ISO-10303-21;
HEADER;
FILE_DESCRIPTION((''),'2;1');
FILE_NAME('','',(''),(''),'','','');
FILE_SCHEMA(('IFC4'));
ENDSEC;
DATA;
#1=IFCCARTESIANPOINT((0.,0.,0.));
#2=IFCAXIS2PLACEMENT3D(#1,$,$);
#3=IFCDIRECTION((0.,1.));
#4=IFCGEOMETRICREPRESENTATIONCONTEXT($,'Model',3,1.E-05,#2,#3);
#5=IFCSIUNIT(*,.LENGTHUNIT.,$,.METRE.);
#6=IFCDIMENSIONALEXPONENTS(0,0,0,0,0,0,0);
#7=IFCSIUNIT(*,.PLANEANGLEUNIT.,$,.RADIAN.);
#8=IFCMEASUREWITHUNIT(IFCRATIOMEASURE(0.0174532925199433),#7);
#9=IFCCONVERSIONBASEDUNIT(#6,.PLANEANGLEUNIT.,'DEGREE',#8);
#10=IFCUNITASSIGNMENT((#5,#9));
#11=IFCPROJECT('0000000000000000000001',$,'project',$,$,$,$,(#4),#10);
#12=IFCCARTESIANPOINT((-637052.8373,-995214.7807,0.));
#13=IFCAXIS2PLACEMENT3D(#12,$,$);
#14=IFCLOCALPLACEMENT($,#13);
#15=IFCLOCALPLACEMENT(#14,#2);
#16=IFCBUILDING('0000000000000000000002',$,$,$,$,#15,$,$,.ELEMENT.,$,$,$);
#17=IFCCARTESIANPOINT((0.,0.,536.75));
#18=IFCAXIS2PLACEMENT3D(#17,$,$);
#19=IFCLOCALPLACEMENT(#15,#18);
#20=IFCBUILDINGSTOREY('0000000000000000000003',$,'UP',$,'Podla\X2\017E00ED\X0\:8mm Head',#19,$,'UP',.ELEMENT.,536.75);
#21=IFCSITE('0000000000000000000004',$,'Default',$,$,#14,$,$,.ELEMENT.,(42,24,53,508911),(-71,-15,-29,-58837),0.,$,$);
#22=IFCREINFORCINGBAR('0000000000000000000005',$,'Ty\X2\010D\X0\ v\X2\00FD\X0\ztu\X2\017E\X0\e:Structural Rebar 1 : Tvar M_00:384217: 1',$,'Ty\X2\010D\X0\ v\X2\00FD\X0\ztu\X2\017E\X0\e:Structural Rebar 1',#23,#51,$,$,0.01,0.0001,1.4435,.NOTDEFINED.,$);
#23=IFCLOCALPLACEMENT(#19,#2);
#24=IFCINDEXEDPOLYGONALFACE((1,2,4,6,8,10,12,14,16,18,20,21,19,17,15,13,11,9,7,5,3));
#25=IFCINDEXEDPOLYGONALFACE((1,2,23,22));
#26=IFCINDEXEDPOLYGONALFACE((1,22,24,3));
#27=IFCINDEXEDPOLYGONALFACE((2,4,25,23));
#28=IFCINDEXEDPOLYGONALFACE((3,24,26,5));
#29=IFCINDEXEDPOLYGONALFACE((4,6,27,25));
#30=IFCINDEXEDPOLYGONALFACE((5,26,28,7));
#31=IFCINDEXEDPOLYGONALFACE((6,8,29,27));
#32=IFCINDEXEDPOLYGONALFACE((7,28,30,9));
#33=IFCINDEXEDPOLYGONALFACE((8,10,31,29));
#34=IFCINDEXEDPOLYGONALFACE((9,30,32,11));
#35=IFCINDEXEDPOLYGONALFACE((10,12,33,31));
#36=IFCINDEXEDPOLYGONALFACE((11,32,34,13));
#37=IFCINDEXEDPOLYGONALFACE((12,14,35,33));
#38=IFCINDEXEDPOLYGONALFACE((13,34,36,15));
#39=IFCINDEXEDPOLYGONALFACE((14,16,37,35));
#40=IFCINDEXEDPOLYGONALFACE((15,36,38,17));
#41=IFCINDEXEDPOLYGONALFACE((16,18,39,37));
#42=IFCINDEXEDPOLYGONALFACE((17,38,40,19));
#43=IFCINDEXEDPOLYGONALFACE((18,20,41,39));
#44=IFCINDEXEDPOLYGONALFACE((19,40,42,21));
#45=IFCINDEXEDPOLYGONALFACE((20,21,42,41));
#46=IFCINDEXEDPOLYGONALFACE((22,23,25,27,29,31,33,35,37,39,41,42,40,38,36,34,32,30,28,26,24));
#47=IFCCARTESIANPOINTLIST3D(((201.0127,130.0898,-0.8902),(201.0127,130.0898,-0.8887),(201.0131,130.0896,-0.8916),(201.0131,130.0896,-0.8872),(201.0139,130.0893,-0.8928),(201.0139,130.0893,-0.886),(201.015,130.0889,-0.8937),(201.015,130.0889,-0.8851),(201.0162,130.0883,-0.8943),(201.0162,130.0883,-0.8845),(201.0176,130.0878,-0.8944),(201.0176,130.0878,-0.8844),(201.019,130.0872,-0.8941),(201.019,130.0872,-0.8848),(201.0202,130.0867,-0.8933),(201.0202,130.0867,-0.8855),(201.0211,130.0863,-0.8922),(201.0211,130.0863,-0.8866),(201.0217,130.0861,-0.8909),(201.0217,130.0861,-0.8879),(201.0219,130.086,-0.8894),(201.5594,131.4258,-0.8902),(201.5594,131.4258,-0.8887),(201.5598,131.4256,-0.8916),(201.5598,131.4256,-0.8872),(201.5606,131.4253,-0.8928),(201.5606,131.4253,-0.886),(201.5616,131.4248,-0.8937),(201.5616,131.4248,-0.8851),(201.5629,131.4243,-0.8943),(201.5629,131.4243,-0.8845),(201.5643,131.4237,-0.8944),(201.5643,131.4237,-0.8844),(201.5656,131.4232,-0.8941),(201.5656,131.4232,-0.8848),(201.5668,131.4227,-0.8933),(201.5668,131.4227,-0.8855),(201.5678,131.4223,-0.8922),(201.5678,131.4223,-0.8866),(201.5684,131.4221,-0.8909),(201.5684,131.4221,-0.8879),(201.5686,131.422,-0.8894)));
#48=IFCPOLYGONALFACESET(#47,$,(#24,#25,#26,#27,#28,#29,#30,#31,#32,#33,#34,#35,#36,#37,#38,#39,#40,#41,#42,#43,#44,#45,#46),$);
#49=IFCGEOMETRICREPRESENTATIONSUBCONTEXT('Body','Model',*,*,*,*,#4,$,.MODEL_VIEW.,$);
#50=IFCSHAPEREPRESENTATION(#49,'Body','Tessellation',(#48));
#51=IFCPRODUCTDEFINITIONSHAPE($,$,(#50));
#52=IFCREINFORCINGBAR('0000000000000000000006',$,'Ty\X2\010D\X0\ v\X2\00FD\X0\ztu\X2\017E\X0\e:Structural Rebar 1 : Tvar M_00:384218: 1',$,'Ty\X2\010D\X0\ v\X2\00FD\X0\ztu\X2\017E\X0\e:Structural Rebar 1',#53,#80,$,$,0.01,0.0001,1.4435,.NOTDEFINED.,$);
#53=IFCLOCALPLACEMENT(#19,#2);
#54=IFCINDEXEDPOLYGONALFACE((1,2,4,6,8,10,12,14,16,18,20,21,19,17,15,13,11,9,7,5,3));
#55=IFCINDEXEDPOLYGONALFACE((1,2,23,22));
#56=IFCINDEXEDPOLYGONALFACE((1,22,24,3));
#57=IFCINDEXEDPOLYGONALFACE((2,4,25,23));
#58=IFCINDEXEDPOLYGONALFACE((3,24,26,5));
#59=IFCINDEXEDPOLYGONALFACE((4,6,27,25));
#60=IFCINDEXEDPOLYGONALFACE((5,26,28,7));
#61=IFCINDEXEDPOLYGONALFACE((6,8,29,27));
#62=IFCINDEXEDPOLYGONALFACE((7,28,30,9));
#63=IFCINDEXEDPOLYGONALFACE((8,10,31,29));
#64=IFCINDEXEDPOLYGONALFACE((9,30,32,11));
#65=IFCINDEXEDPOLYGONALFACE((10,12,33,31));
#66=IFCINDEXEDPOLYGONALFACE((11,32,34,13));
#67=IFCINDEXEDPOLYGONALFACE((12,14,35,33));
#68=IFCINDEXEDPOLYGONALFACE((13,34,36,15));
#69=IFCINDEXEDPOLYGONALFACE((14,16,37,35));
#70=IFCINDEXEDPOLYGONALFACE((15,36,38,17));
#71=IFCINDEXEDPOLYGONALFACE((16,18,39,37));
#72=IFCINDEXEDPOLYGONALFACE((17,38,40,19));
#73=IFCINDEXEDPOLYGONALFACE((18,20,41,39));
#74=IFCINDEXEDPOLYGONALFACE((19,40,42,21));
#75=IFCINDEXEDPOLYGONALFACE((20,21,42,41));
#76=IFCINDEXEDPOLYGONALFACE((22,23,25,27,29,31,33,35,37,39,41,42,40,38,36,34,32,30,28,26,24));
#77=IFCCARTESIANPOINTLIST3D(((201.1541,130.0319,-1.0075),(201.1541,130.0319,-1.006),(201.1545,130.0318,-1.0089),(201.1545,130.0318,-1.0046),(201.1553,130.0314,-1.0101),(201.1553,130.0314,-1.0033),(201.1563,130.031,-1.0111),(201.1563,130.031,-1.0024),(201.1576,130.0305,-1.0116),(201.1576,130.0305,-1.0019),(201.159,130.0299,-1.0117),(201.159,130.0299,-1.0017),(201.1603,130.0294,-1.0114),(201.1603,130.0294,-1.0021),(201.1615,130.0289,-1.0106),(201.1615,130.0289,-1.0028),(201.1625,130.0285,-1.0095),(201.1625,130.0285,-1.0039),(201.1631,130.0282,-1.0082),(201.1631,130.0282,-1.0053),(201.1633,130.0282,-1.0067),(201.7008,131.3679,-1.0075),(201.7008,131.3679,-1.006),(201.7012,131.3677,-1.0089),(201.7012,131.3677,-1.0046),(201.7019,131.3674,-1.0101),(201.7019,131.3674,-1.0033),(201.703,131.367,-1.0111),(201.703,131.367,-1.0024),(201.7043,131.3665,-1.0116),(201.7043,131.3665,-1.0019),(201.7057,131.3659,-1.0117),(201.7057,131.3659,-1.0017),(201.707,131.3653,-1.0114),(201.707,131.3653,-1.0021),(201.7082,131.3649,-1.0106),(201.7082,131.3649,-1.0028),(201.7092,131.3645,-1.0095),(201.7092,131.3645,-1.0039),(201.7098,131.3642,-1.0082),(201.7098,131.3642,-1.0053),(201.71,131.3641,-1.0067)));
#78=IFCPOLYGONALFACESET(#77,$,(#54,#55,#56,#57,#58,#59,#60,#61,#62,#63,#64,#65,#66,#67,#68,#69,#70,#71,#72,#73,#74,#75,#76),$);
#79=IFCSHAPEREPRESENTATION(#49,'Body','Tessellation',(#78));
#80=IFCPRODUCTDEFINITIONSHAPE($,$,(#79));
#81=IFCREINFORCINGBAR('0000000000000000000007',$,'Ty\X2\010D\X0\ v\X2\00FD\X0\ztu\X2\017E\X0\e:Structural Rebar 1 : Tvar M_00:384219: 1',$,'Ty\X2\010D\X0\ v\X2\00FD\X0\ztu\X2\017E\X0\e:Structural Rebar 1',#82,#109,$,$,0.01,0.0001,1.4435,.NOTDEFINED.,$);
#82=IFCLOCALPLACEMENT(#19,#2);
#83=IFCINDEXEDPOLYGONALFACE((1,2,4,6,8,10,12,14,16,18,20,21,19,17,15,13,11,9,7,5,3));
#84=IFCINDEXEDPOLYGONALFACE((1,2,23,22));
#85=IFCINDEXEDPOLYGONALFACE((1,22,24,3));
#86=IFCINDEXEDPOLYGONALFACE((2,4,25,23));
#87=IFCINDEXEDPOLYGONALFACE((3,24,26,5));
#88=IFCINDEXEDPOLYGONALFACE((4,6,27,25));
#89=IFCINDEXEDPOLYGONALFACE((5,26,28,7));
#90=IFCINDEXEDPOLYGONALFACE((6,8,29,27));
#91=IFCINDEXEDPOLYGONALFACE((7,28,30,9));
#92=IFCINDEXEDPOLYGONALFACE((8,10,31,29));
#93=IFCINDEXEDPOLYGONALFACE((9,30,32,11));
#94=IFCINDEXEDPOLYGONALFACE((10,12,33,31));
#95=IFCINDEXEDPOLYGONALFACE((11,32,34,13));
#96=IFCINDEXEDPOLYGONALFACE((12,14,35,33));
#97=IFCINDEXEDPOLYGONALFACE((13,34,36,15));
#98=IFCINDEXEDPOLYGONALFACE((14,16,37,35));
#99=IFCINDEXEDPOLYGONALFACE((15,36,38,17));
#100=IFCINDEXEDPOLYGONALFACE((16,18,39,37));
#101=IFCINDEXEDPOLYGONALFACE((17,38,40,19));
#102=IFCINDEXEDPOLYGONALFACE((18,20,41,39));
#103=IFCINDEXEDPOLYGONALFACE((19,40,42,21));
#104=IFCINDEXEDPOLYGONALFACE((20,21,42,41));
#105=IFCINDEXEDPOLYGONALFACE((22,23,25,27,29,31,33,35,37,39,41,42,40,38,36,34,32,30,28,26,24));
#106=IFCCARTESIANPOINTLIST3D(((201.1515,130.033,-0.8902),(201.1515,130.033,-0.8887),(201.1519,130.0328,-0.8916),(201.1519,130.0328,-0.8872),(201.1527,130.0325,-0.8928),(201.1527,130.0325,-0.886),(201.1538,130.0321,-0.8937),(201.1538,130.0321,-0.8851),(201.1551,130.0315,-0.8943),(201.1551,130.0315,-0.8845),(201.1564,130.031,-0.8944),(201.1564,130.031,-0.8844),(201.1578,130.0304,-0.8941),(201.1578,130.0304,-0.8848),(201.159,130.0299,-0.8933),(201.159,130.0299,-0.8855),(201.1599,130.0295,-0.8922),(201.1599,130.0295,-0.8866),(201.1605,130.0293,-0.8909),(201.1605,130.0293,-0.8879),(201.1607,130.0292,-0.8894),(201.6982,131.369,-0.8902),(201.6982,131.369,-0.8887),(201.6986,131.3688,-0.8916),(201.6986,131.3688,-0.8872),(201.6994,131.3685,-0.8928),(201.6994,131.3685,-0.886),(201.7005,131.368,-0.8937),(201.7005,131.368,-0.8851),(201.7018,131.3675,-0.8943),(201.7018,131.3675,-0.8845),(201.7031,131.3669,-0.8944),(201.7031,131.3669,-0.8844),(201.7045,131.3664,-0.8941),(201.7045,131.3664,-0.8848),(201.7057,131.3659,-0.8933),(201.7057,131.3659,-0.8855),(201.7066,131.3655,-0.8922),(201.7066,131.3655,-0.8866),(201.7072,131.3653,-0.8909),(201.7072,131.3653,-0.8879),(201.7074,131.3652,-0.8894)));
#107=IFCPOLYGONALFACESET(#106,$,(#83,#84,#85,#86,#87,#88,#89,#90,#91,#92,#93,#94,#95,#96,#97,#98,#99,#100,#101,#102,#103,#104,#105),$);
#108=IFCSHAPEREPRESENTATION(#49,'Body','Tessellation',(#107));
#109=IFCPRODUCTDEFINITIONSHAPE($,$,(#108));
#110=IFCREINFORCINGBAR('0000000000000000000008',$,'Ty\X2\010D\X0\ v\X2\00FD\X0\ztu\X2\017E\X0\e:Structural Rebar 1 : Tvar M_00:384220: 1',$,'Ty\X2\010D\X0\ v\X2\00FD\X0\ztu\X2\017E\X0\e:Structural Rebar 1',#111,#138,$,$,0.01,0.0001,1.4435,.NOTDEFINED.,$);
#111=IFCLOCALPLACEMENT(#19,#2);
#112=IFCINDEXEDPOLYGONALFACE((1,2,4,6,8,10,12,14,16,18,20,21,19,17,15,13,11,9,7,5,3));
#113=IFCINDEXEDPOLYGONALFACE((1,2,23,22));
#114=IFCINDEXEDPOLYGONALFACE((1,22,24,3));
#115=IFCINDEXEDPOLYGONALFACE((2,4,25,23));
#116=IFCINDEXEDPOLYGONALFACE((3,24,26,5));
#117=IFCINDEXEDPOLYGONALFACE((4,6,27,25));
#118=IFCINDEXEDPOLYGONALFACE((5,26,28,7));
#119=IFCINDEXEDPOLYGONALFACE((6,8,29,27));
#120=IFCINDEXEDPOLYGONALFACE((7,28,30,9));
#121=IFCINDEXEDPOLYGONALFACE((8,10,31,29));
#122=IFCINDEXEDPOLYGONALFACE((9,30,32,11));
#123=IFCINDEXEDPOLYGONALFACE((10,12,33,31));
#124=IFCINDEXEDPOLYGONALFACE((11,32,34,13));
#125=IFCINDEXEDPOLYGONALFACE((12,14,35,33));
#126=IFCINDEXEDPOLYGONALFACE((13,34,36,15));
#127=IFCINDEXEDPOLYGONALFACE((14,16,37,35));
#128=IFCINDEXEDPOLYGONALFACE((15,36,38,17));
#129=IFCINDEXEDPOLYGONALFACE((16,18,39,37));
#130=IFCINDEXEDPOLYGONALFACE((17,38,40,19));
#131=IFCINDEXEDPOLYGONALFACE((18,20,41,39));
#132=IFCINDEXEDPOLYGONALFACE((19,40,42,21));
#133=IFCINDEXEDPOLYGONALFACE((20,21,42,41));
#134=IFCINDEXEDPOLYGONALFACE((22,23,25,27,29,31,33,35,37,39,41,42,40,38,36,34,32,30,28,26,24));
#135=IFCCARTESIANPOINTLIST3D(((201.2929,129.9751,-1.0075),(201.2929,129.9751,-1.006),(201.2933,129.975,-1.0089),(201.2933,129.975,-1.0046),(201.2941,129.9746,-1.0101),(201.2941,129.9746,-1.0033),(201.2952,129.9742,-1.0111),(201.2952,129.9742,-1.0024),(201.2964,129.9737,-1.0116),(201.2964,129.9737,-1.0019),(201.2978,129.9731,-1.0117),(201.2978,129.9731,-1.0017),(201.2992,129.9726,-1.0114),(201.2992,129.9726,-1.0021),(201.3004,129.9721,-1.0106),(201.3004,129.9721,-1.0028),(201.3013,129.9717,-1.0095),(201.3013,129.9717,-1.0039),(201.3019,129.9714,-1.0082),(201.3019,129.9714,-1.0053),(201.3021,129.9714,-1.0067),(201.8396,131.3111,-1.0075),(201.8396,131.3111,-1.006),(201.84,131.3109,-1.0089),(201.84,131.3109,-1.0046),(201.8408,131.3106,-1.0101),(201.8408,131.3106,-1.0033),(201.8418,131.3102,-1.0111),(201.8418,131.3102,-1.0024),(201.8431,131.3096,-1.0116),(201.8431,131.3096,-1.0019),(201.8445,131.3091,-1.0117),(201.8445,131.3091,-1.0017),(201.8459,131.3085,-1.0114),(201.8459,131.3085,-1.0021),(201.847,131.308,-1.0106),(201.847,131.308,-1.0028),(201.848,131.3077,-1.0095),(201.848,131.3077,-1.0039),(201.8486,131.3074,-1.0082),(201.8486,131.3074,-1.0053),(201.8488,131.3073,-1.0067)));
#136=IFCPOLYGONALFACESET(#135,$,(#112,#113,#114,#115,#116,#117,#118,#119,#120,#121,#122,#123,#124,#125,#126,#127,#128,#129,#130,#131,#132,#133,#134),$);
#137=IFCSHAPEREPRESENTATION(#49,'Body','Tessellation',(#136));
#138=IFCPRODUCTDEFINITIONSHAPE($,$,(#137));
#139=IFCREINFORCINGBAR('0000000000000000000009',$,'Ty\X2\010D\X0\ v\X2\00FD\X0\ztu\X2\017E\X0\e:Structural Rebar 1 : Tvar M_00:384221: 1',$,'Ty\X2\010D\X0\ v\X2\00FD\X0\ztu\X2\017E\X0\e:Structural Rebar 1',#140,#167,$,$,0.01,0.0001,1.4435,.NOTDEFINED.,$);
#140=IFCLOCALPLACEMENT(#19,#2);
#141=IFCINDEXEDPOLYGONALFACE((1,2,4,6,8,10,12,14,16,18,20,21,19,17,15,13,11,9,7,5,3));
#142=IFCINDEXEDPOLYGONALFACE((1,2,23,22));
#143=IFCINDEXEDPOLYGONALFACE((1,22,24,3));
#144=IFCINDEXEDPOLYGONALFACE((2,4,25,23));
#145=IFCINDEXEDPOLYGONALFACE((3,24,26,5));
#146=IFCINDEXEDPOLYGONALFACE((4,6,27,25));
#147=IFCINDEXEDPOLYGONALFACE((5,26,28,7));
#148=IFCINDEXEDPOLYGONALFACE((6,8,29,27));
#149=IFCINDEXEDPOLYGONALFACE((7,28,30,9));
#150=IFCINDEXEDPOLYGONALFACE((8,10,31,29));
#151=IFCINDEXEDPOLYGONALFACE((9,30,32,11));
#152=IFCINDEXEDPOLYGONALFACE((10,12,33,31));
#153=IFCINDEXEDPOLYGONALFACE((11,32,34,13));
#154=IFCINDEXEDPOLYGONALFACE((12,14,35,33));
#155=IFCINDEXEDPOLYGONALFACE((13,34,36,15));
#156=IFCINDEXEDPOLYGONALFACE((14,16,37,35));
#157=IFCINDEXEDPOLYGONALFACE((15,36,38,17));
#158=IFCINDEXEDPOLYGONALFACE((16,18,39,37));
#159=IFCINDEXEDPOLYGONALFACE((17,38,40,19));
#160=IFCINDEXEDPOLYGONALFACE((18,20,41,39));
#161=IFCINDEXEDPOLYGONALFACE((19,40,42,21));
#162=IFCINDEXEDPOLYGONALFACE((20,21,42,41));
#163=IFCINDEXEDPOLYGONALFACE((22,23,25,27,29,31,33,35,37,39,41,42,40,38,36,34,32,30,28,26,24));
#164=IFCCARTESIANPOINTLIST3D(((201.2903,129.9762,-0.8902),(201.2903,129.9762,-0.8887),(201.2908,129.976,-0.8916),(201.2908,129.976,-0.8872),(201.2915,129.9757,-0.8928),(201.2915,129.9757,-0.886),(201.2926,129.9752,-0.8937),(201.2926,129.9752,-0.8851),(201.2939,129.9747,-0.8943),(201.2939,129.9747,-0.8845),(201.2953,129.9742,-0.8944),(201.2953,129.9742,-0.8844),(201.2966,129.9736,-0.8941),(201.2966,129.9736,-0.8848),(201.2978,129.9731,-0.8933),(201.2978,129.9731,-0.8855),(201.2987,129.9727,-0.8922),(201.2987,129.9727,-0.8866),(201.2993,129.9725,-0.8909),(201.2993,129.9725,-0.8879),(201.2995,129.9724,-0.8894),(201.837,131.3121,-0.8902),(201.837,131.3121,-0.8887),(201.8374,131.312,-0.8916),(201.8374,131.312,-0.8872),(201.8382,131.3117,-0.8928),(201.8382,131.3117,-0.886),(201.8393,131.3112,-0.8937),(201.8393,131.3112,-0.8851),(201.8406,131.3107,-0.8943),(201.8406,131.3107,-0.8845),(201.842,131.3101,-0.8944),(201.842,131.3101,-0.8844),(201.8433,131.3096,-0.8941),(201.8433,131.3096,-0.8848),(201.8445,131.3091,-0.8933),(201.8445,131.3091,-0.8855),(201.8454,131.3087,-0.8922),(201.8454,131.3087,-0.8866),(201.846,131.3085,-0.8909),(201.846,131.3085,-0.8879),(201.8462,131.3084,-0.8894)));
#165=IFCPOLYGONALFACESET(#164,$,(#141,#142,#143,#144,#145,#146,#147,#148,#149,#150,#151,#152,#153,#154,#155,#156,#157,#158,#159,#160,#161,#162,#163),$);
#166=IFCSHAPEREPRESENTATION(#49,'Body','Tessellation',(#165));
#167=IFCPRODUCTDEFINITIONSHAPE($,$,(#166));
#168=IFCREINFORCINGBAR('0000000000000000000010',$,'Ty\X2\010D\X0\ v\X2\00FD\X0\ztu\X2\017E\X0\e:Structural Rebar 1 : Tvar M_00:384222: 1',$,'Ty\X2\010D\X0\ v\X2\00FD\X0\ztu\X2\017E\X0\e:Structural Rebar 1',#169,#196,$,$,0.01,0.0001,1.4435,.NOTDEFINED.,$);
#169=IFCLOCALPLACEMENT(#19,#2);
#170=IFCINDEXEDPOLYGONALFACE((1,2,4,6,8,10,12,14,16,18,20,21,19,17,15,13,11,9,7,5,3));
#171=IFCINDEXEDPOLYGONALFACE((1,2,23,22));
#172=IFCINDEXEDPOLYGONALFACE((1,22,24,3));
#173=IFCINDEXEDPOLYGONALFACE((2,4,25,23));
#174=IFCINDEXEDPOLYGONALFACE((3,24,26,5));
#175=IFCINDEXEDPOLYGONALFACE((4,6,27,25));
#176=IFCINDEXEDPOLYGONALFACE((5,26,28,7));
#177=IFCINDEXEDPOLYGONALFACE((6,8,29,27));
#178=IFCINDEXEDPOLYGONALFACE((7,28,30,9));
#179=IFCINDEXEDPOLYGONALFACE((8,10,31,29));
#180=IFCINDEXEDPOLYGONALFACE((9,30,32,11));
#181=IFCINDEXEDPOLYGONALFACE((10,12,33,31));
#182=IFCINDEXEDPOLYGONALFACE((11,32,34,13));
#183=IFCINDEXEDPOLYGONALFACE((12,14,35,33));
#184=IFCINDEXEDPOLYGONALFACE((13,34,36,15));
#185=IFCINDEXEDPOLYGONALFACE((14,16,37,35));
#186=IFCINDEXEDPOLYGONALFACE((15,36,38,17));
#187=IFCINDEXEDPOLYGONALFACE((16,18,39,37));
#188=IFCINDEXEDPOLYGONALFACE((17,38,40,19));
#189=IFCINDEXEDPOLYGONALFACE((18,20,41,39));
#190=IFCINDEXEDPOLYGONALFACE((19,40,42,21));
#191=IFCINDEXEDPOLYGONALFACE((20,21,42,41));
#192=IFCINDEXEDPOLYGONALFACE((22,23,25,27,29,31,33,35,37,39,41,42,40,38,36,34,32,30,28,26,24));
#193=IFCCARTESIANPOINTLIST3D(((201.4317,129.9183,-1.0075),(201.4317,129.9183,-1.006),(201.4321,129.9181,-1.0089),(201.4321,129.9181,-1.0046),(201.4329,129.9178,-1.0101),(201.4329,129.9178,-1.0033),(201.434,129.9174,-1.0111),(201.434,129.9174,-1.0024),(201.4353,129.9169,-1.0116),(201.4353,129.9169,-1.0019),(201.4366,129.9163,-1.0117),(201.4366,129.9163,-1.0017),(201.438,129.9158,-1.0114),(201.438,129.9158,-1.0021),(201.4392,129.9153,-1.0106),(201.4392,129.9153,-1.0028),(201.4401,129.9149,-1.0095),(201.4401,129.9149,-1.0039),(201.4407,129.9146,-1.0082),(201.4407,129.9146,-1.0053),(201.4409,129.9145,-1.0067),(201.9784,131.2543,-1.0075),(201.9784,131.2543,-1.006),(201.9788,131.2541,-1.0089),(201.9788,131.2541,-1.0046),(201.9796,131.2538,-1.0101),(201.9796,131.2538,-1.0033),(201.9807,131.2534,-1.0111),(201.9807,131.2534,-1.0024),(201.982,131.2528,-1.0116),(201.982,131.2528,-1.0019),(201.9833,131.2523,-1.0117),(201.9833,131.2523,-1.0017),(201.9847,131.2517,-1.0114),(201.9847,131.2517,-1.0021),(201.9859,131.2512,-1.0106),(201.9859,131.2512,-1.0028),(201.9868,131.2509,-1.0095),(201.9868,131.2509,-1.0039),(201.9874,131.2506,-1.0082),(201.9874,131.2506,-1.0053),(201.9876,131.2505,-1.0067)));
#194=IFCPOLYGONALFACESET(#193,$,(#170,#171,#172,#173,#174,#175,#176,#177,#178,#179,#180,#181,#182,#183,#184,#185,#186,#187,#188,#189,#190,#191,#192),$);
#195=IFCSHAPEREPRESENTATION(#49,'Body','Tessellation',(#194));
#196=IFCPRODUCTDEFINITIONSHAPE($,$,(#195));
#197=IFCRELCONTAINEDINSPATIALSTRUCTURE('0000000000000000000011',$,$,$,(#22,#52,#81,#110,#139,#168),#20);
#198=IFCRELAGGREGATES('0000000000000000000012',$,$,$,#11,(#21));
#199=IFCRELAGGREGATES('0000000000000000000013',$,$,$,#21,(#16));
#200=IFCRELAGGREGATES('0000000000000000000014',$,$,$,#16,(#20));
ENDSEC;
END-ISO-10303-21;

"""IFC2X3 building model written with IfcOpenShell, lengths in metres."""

from ifc_helpers import new_model, entity, si_unit, converted_unit, direction, frame, origin, place, context, subcontext, project, spatial, element, save


model = new_model("IFC2X3")

# Units and contexts
model_context = context("Model", 3, precision=1e-05, world=origin(), true_north=direction((0.0, 1.0)))
body_context = subcontext(model_context, "Body", "Model", "MODEL_VIEW")
ifc_project = project(units=[si_unit("LENGTHUNIT", "METRE"), converted_unit("PLANEANGLEUNIT", "DEGREE", entity("IfcRatioMeasure", 0.0174532925199433), si_unit("PLANEANGLEUNIT", "RADIAN"), dimensions=[0, 0, 0, 0, 0, 0, 0])], contexts=[model_context])

# Site, building, storey
site_placement = place(None, frame((-637052.8373, -995214.7807, 0.0)))
site = spatial("IfcSite", under=ifc_project, at=site_placement, Name="Default", CompositionType="ELEMENT", RefLatitude=(42, 24, 53, 508911), RefLongitude=(-71, -15, -29, -58837), RefElevation=0.0)
building_placement = place(site_placement, origin())
building = spatial("IfcBuilding", under=site, at=building_placement, CompositionType="ELEMENT")
storey_placement = place(building_placement, frame((0.0, 0.0, 536.75)))
storey = spatial("IfcBuildingStorey", under=building, at=storey_placement, Name="UP", ObjectType="Podlaží:8mm Head", LongName="UP", CompositionType="ELEMENT", Elevation=536.75)

# Reinforcing bars
reinforcing_bar_1_placement = place(storey_placement, origin())
element("IfcReinforcingBar", 1, at=reinforcing_bar_1_placement, inside=storey, Name="Tyč výztuže:Structural Rebar 1 : Tvar M_00:384217: 1", ObjectType="Tyč výztuže:Structural Rebar 1", BarLength=1.4435, BarRole="NOTDEFINED", CrossSectionArea=0.0001, NominalDiameter=0.01, context=body_context, shape_type="AdvancedSweptSolid", body=[
    entity("IfcSweptDiskSolid", entity("IfcCompositeCurve", [entity("IfcCompositeCurveSegment", "CONTINUOUS", True, entity("IfcPolyline", [entity("IfcCartesianPoint", [-201.564, -131.4239, 0.8894]), entity("IfcCartesianPoint", [-201.0173, -130.0879, 0.8894])]))], False), 0.005, None, 0.0, 1.0),
])
reinforcing_bar_2_placement = place(storey_placement, origin())
element("IfcReinforcingBar", 2, at=reinforcing_bar_2_placement, inside=storey, Name="Tyč výztuže:Structural Rebar 1 : Tvar M_00:384218: 1", ObjectType="Tyč výztuže:Structural Rebar 1", BarLength=1.4435, BarRole="NOTDEFINED", CrossSectionArea=0.0001, NominalDiameter=0.01, context=body_context, shape_type="AdvancedSweptSolid", body=[
    entity("IfcSweptDiskSolid", entity("IfcCompositeCurve", [entity("IfcCompositeCurveSegment", "CONTINUOUS", True, entity("IfcPolyline", [entity("IfcCartesianPoint", [-201.7053, -131.366, 1.0067]), entity("IfcCartesianPoint", [-201.1586, -130.0301, 1.0067])]))], False), 0.005, None, 0.0, 1.0),
])
reinforcing_bar_3_placement = place(storey_placement, origin())
element("IfcReinforcingBar", 3, at=reinforcing_bar_3_placement, inside=storey, Name="Tyč výztuže:Structural Rebar 1 : Tvar M_00:384219: 1", ObjectType="Tyč výztuže:Structural Rebar 1", BarLength=1.4435, BarRole="NOTDEFINED", CrossSectionArea=0.0001, NominalDiameter=0.01, context=body_context, shape_type="AdvancedSweptSolid", body=[
    entity("IfcSweptDiskSolid", entity("IfcCompositeCurve", [entity("IfcCompositeCurveSegment", "CONTINUOUS", True, entity("IfcPolyline", [entity("IfcCartesianPoint", [-201.7028, -131.3671, 0.8894]), entity("IfcCartesianPoint", [-201.1561, -130.0311, 0.8894])]))], False), 0.005, None, 0.0, 1.0),
])
reinforcing_bar_4_placement = place(storey_placement, origin())
element("IfcReinforcingBar", 4, at=reinforcing_bar_4_placement, inside=storey, Name="Tyč výztuže:Structural Rebar 1 : Tvar M_00:384220: 1", ObjectType="Tyč výztuže:Structural Rebar 1", BarLength=1.4435, BarRole="NOTDEFINED", CrossSectionArea=0.0001, NominalDiameter=0.01, context=body_context, shape_type="AdvancedSweptSolid", body=[
    entity("IfcSweptDiskSolid", entity("IfcCompositeCurve", [entity("IfcCompositeCurveSegment", "CONTINUOUS", True, entity("IfcPolyline", [entity("IfcCartesianPoint", [-201.8442, -131.3092, 1.0067]), entity("IfcCartesianPoint", [-201.2975, -129.9733, 1.0067])]))], False), 0.005, None, 0.0, 1.0),
])
reinforcing_bar_5_placement = place(storey_placement, origin())
element("IfcReinforcingBar", 5, at=reinforcing_bar_5_placement, inside=storey, Name="Tyč výztuže:Structural Rebar 1 : Tvar M_00:384221: 1", ObjectType="Tyč výztuže:Structural Rebar 1", BarLength=1.4435, BarRole="NOTDEFINED", CrossSectionArea=0.0001, NominalDiameter=0.01, context=body_context, shape_type="AdvancedSweptSolid", body=[
    entity("IfcSweptDiskSolid", entity("IfcCompositeCurve", [entity("IfcCompositeCurveSegment", "CONTINUOUS", True, entity("IfcPolyline", [entity("IfcCartesianPoint", [-201.8416, -131.3103, 0.8894]), entity("IfcCartesianPoint", [-201.2949, -129.9743, 0.8894])]))], False), 0.005, None, 0.0, 1.0),
])
reinforcing_bar_6_placement = place(storey_placement, origin())
element("IfcReinforcingBar", 6, at=reinforcing_bar_6_placement, inside=storey, Name="Tyč výztuže:Structural Rebar 1 : Tvar M_00:384222: 1", ObjectType="Tyč výztuže:Structural Rebar 1", BarLength=1.4435, BarRole="NOTDEFINED", CrossSectionArea=0.0001, NominalDiameter=0.01, context=body_context, shape_type="AdvancedSweptSolid", body=[
    entity("IfcSweptDiskSolid", entity("IfcCompositeCurve", [entity("IfcCompositeCurveSegment", "CONTINUOUS", True, entity("IfcPolyline", [entity("IfcCartesianPoint", [-201.983, -131.2524, 1.0067]), entity("IfcCartesianPoint", [-201.4363, -129.9164, 1.0067])]))], False), 0.005, None, 0.0, 1.0),
])

save(model, "model.ifc")
